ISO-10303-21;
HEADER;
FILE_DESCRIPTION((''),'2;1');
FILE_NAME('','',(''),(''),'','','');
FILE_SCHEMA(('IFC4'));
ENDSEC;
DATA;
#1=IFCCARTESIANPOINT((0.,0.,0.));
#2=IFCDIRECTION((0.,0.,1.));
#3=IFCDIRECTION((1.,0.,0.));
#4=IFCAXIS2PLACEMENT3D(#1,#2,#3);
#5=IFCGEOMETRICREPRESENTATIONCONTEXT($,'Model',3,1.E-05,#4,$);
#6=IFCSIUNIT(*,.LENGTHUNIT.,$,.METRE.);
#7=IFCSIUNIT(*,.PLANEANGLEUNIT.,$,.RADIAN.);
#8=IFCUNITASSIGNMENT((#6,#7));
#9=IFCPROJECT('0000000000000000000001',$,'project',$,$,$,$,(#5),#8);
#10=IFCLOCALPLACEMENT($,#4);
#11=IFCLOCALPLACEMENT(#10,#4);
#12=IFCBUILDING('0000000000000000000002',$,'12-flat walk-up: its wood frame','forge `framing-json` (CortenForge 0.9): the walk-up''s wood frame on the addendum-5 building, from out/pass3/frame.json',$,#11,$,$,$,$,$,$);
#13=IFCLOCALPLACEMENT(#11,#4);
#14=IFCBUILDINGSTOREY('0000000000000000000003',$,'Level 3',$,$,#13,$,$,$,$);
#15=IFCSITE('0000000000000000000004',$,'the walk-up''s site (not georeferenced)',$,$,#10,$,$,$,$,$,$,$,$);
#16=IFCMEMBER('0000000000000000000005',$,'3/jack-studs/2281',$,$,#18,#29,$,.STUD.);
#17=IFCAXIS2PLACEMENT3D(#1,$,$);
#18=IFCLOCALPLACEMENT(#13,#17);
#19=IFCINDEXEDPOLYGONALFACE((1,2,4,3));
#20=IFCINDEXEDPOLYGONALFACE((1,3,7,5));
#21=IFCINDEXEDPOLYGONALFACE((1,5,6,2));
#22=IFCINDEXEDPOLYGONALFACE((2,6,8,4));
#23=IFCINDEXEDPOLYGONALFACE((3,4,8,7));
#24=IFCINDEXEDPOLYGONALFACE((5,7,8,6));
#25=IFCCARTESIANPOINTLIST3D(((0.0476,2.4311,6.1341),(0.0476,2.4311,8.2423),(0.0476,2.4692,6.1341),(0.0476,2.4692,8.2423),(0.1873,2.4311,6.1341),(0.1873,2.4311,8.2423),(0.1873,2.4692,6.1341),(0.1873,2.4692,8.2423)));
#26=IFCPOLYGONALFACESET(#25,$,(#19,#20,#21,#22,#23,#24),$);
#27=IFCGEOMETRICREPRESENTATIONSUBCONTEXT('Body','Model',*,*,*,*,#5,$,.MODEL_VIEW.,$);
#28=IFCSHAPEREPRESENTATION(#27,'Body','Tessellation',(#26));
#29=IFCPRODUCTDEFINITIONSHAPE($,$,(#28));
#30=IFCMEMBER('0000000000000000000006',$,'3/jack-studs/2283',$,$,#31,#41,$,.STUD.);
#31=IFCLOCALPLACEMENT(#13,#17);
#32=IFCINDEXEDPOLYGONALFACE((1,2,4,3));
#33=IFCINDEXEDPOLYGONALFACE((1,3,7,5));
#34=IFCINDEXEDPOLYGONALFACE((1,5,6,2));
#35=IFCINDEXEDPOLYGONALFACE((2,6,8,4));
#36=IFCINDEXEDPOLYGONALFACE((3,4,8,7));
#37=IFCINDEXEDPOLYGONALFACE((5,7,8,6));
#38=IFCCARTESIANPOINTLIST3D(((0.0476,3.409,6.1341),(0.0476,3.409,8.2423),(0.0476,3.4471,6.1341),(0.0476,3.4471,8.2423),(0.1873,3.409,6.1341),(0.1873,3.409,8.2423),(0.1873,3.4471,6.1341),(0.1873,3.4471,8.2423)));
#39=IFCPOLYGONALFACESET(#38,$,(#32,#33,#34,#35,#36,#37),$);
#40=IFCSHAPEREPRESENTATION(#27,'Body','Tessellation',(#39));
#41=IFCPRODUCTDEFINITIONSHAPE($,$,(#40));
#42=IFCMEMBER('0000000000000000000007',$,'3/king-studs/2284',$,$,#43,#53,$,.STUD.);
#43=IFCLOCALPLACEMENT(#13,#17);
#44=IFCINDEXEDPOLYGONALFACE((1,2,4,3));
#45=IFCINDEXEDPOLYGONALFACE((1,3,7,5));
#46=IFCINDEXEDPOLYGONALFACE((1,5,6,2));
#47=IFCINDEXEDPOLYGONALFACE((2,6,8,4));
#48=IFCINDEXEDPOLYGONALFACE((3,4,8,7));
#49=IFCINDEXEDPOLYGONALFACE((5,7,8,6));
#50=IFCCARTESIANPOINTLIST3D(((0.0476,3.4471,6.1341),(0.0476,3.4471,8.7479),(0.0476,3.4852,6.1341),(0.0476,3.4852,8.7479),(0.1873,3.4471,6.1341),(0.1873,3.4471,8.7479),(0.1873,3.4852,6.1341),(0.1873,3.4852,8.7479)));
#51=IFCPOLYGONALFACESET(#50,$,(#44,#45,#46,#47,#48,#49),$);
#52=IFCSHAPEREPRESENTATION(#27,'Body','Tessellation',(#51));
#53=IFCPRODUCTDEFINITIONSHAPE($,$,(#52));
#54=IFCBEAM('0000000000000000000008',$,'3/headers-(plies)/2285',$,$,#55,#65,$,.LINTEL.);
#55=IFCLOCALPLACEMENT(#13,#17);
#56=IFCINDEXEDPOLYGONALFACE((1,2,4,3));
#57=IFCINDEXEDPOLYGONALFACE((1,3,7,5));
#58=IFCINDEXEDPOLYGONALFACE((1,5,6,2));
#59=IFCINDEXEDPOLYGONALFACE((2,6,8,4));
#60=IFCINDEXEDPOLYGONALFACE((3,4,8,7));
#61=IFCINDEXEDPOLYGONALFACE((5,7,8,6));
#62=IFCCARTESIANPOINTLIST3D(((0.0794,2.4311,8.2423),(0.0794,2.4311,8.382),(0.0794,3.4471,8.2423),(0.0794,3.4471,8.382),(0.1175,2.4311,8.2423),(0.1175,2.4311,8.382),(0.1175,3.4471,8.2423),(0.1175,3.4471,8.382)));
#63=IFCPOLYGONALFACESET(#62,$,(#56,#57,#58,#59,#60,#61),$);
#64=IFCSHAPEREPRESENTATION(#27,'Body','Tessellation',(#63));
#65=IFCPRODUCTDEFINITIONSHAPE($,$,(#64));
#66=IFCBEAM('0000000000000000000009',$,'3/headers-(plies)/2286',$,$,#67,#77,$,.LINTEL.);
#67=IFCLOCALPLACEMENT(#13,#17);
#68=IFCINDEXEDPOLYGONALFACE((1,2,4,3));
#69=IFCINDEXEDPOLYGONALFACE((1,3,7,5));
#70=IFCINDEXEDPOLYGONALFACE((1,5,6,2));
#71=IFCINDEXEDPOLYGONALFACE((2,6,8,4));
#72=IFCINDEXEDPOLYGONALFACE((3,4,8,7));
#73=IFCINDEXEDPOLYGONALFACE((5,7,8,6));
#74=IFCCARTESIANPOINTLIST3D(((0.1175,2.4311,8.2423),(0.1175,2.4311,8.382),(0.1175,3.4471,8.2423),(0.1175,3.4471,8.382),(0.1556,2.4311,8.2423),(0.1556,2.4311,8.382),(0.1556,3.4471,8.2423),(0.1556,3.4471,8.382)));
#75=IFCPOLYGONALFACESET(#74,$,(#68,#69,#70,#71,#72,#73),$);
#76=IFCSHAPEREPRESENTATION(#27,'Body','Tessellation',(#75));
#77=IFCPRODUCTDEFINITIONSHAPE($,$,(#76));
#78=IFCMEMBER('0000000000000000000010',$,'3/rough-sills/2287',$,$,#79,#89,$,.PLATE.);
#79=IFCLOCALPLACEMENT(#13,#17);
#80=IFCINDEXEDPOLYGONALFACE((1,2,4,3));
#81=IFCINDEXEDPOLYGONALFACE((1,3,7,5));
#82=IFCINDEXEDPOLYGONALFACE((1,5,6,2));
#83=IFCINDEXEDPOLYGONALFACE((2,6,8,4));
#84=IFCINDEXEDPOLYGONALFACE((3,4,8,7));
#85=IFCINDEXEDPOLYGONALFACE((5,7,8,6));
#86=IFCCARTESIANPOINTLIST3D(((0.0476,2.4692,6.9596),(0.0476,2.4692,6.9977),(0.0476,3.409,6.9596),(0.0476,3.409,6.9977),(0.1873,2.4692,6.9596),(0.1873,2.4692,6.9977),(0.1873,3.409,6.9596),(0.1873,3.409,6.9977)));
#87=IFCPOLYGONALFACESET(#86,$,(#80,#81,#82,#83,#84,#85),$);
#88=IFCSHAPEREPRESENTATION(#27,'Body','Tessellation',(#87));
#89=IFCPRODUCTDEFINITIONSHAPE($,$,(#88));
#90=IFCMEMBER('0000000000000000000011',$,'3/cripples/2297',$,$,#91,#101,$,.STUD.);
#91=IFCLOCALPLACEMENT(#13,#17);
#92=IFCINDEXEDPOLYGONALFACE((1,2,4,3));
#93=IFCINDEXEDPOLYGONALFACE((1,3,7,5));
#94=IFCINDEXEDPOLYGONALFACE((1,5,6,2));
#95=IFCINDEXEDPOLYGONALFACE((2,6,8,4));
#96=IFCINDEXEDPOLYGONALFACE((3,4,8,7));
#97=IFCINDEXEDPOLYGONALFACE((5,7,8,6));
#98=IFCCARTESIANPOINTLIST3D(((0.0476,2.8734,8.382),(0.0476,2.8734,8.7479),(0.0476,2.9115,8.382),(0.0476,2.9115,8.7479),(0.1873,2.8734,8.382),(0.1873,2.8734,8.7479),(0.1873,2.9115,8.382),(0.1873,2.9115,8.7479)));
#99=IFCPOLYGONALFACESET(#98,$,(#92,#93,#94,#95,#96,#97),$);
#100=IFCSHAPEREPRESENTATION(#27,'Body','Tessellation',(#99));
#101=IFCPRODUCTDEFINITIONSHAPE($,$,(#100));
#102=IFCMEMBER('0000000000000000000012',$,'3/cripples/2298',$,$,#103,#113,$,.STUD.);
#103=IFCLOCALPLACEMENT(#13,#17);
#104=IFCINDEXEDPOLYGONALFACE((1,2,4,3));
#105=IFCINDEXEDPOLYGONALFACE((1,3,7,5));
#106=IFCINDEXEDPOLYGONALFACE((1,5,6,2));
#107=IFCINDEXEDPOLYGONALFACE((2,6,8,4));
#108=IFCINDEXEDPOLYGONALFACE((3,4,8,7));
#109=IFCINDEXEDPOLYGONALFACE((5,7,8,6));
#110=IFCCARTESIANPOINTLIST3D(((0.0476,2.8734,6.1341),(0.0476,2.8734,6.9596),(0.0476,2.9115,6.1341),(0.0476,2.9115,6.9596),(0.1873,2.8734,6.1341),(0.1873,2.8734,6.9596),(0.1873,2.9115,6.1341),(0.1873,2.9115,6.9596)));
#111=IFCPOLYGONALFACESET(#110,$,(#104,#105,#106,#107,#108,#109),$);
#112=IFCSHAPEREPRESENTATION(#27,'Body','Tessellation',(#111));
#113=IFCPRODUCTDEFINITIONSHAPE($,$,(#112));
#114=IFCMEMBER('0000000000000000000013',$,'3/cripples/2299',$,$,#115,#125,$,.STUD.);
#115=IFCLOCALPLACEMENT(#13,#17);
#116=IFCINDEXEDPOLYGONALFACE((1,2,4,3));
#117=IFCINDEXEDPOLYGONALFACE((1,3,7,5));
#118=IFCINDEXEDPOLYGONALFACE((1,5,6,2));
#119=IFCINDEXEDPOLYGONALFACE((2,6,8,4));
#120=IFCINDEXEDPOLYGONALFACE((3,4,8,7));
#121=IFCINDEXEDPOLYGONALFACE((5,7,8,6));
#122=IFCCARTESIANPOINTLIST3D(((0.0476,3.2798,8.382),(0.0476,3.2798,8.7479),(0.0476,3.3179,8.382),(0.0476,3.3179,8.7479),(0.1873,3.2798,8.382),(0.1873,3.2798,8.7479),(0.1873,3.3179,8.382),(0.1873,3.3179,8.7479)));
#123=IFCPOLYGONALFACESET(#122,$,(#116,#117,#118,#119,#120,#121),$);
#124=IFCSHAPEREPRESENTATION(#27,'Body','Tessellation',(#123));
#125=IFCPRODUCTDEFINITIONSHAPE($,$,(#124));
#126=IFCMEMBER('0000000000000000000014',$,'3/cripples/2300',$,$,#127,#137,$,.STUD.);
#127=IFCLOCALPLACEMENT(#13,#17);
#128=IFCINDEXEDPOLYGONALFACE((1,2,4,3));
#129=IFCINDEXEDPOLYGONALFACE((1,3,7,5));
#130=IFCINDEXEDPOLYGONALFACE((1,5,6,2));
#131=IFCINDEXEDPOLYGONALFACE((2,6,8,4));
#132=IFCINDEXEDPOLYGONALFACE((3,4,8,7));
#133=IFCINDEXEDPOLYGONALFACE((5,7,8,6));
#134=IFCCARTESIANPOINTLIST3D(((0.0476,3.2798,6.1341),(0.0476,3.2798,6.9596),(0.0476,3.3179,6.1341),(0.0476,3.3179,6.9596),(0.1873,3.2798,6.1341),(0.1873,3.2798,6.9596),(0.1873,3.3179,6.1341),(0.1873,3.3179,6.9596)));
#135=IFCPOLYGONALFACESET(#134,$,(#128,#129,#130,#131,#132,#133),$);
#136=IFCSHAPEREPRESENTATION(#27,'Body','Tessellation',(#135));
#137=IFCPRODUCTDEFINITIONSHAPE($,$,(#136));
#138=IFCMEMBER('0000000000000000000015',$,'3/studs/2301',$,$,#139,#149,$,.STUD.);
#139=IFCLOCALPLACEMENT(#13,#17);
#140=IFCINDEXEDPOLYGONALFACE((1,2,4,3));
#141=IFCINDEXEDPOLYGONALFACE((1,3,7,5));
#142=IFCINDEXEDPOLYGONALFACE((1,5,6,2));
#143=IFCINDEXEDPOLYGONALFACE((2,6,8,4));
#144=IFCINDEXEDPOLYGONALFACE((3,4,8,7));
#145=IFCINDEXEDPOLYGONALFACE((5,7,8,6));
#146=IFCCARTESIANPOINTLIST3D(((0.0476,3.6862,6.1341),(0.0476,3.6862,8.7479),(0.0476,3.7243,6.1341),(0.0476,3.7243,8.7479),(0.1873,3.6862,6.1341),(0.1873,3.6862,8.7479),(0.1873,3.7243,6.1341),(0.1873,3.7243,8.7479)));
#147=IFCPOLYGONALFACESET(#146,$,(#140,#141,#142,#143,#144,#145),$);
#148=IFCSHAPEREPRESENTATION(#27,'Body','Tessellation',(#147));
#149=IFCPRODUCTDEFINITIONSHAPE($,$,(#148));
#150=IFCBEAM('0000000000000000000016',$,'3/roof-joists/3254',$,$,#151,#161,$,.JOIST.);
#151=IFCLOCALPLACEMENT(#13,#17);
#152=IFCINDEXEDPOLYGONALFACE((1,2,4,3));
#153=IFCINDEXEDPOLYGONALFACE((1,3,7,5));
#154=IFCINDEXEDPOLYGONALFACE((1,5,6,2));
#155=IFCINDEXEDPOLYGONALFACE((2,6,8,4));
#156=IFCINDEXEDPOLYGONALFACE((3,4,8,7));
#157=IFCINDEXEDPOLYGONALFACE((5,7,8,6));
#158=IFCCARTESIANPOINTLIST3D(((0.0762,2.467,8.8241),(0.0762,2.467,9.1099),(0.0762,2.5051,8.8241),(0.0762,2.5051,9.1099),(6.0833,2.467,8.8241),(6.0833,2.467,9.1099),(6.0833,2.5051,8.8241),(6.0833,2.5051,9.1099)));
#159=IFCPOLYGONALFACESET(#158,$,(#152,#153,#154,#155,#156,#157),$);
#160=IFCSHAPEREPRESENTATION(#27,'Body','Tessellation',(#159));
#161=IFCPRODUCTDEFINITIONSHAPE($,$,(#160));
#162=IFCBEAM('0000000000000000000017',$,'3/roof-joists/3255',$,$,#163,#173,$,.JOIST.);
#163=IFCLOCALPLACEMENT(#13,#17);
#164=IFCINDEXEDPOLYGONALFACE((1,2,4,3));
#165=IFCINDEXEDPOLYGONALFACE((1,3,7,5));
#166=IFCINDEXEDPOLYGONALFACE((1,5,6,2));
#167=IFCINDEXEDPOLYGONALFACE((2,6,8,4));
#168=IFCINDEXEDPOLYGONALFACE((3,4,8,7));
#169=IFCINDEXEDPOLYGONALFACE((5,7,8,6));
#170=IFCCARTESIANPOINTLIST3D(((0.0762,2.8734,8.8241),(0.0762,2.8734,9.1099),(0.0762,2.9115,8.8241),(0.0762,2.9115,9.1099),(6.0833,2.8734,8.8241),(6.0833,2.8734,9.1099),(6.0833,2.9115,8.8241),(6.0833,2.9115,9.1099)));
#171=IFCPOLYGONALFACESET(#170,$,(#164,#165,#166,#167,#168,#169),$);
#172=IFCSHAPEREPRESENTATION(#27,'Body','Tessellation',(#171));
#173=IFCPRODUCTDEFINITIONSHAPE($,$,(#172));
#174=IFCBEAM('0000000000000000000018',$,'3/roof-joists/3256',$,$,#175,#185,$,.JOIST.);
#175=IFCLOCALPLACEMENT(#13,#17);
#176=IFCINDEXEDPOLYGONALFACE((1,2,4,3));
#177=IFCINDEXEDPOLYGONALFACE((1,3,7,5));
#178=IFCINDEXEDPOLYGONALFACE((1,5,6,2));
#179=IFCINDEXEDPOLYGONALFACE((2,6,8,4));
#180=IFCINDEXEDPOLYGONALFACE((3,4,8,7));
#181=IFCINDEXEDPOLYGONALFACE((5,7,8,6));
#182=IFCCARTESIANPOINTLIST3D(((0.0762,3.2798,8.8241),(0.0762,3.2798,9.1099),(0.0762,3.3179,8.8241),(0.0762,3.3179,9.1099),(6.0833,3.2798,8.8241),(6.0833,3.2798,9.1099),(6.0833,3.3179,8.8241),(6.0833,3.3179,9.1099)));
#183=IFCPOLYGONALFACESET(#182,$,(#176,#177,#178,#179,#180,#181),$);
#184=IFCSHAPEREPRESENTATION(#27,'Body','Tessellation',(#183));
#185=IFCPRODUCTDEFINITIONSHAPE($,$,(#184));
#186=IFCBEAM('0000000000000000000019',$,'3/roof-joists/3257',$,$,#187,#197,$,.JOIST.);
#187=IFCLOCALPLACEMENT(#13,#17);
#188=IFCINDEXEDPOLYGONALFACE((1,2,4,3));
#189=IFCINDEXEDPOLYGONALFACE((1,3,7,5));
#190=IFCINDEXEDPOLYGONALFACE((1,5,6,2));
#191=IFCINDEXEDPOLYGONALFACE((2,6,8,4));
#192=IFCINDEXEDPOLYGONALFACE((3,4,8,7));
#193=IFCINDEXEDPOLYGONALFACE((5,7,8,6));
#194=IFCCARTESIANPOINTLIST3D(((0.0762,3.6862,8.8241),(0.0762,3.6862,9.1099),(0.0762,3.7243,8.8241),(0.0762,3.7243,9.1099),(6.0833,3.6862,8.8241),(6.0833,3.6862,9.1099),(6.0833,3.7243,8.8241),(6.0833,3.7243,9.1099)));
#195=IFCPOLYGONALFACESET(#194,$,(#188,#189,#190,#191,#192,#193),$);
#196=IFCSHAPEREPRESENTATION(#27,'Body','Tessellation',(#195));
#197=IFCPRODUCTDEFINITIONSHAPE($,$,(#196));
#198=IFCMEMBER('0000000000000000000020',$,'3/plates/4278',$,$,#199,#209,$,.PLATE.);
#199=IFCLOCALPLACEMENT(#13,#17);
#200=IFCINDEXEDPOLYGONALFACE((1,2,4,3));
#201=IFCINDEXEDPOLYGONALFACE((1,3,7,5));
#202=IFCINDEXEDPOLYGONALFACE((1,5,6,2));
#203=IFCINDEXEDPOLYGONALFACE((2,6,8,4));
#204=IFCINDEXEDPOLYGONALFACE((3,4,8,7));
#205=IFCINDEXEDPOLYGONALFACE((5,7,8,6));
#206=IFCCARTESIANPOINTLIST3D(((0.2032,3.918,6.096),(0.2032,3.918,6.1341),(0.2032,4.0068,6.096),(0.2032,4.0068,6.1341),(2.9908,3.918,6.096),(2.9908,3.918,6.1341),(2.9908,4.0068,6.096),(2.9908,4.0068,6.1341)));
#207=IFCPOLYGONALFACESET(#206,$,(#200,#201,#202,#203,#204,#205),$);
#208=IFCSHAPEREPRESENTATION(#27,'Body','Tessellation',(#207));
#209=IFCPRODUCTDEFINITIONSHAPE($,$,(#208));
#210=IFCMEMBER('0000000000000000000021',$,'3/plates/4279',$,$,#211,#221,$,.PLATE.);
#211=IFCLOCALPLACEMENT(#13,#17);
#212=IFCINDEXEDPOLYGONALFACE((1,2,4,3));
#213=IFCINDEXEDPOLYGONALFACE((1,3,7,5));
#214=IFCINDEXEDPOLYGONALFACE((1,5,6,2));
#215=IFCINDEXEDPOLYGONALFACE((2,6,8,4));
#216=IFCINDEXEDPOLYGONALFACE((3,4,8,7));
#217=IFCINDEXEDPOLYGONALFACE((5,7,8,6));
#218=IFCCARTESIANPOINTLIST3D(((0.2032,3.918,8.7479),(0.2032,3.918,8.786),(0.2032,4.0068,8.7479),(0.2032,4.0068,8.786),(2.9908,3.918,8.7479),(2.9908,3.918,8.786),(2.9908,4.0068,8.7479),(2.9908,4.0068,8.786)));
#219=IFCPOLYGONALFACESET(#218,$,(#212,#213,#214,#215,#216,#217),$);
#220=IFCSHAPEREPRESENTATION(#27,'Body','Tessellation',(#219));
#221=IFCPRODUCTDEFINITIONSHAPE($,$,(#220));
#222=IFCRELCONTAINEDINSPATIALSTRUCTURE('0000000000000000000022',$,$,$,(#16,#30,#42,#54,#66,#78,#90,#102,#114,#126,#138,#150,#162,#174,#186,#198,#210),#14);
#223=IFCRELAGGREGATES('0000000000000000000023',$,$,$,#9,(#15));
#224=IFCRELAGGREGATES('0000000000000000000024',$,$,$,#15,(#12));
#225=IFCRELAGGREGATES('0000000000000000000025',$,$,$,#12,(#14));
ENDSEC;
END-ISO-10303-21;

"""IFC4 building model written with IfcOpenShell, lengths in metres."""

from ifc_helpers import new_model, si_unit, frame, frame_2d, origin, origin_with_axes, place, context, subcontext, project, spatial, rectangle, extrude, element, save


model = new_model("IFC4")

# Units and contexts
model_context = context("Model", 3, precision=1e-05, world=origin_with_axes())
body_context = subcontext(model_context, "Body", "Model", "MODEL_VIEW")
ifc_project = project(units=[si_unit("LENGTHUNIT", "METRE"), si_unit("PLANEANGLEUNIT", "RADIAN")], contexts=[model_context])

# Site, building, storey
site_placement = place(None, origin_with_axes())
site = spatial("IfcSite", under=ifc_project, at=site_placement, Name="the walk-up's site (not georeferenced)")
building_placement = place(site_placement, origin_with_axes())
building = spatial("IfcBuilding", under=site, at=building_placement, Name="12-flat walk-up: its wood frame", Description="forge `framing-json` (CortenForge 0.9): the walk-up's wood frame on the addendum-5 building, from out/pass3/frame.json")
storey_placement = place(building_placement, origin_with_axes())
storey = spatial("IfcBuildingStorey", under=building, at=storey_placement, Name="Level 3")

# Members
for number, where, z_axis, x_axis, name in (
    (1, (0.0476, 2.4311, 6.1341), (0.0, 0.0, 1.0), (1.0, 0.0, 0.0), "3/jack-studs/2281"),
    (2, (0.0476, 3.409, 6.1341), (0.0, 0.0, 1.0), (1.0, 0.0, 0.0), "3/jack-studs/2283"),
):
    element("IfcMember", number, at=place(storey_placement, frame(where, z_axis=z_axis, x_axis=x_axis)), inside=storey, Name=name, PredefinedType="STUD", context=body_context, shape_type="SweptSolid", body=[
        extrude(rectangle(XDim=0.1397, YDim=0.0381, at=frame_2d((0.0698, 0.0191))), origin(), (0.0, 0.0, 1.0), 2.1082),
    ])
member_1_placement = place(storey_placement, frame((0.0476, 3.4471, 6.1341), z_axis=(0.0, 0.0, 1.0), x_axis=(1.0, 0.0, 0.0)))
element("IfcMember", 3, at=member_1_placement, inside=storey, Name="3/king-studs/2284", PredefinedType="STUD", context=body_context, shape_type="SweptSolid", body=[
    extrude(rectangle(XDim=0.1397, YDim=0.0381, at=frame_2d((0.0698, 0.0191))), origin(), (0.0, 0.0, 1.0), 2.6138),
])

# Beams
for number, where, z_axis, x_axis, name in (
    (4, (0.0794, 2.4311, 8.2423), (0.0, 0.0, 1.0), (1.0, 0.0, 0.0), "3/headers-(plies)/2285"),
    (5, (0.1175, 2.4311, 8.2423), (0.0, 0.0, 1.0), (1.0, 0.0, 0.0), "3/headers-(plies)/2286"),
):
    element("IfcBeam", number, at=place(storey_placement, frame(where, z_axis=z_axis, x_axis=x_axis)), inside=storey, Name=name, PredefinedType="LINTEL", context=body_context, shape_type="SweptSolid", body=[
        extrude(rectangle(XDim=0.0381, YDim=1.016, at=frame_2d((0.019, 0.508))), origin(), (0.0, 0.0, 1.0), 0.1397),
    ])

# Members
member_2_placement = place(storey_placement, frame((0.0476, 2.4692, 6.9596), z_axis=(0.0, 0.0, 1.0), x_axis=(1.0, 0.0, 0.0)))
element("IfcMember", 6, at=member_2_placement, inside=storey, Name="3/rough-sills/2287", PredefinedType="PLATE", context=body_context, shape_type="SweptSolid", body=[
    extrude(rectangle(XDim=0.1397, YDim=0.9398, at=frame_2d((0.0698, 0.4699))), origin(), (0.0, 0.0, 1.0), 0.0381),
])
member_3_placement = place(storey_placement, frame((0.0476, 2.8734, 8.382), z_axis=(0.0, 0.0, 1.0), x_axis=(1.0, 0.0, 0.0)))
element("IfcMember", 7, at=member_3_placement, inside=storey, Name="3/cripples/2297", PredefinedType="STUD", context=body_context, shape_type="SweptSolid", body=[
    extrude(rectangle(XDim=0.1397, YDim=0.0381, at=frame_2d((0.0698, 0.0191))), origin(), (0.0, 0.0, 1.0), 0.3659),
])
member_4_placement = place(storey_placement, frame((0.0476, 2.8734, 6.1341), z_axis=(0.0, 0.0, 1.0), x_axis=(1.0, 0.0, 0.0)))
element("IfcMember", 8, at=member_4_placement, inside=storey, Name="3/cripples/2298", PredefinedType="STUD", context=body_context, shape_type="SweptSolid", body=[
    extrude(rectangle(XDim=0.1397, YDim=0.0381, at=frame_2d((0.0698, 0.0191))), origin(), (0.0, 0.0, 1.0), 0.8255),
])
member_5_placement = place(storey_placement, frame((0.0476, 3.2798, 8.382), z_axis=(0.0, 0.0, 1.0), x_axis=(1.0, 0.0, 0.0)))
element("IfcMember", 9, at=member_5_placement, inside=storey, Name="3/cripples/2299", PredefinedType="STUD", context=body_context, shape_type="SweptSolid", body=[
    extrude(rectangle(XDim=0.1397, YDim=0.0381, at=frame_2d((0.0698, 0.0191))), origin(), (0.0, 0.0, 1.0), 0.3659),
])
member_6_placement = place(storey_placement, frame((0.0476, 3.2798, 6.1341), z_axis=(0.0, 0.0, 1.0), x_axis=(1.0, 0.0, 0.0)))
element("IfcMember", 10, at=member_6_placement, inside=storey, Name="3/cripples/2300", PredefinedType="STUD", context=body_context, shape_type="SweptSolid", body=[
    extrude(rectangle(XDim=0.1397, YDim=0.0381, at=frame_2d((0.0698, 0.0191))), origin(), (0.0, 0.0, 1.0), 0.8255),
])
member_7_placement = place(storey_placement, frame((0.0476, 3.6862, 6.1341), z_axis=(0.0, 0.0, 1.0), x_axis=(1.0, 0.0, 0.0)))
element("IfcMember", 11, at=member_7_placement, inside=storey, Name="3/studs/2301", PredefinedType="STUD", context=body_context, shape_type="SweptSolid", body=[
    extrude(rectangle(XDim=0.1397, YDim=0.0381, at=frame_2d((0.0698, 0.0191))), origin(), (0.0, 0.0, 1.0), 2.6138),
])

# Beams
for number, where, z_axis, x_axis, name in (
    (12, (0.0762, 2.467, 8.8241), (0.0, 0.0, 1.0), (1.0, 0.0, 0.0), "3/roof-joists/3254"),
    (13, (0.0762, 2.8734, 8.8241), (0.0, 0.0, 1.0), (1.0, 0.0, 0.0), "3/roof-joists/3255"),
    (14, (0.0762, 3.2798, 8.8241), (0.0, 0.0, 1.0), (1.0, 0.0, 0.0), "3/roof-joists/3256"),
    (15, (0.0762, 3.6862, 8.8241), (0.0, 0.0, 1.0), (1.0, 0.0, 0.0), "3/roof-joists/3257"),
):
    element("IfcBeam", number, at=place(storey_placement, frame(where, z_axis=z_axis, x_axis=x_axis)), inside=storey, Name=name, PredefinedType="JOIST", context=body_context, shape_type="SweptSolid", body=[
        extrude(rectangle(XDim=6.0071, YDim=0.0381, at=frame_2d((3.0036, 0.0191))), origin(), (0.0, 0.0, 1.0), 0.2858),
    ])

# Members
for number, where, z_axis, x_axis, name in (
    (16, (0.2032, 3.9179, 6.096), (0.0, 0.0, 1.0), (1.0, 0.0, 0.0), "3/plates/4278"),
    (17, (0.2032, 3.9179, 8.7479), (0.0, 0.0, 1.0), (1.0, 0.0, 0.0), "3/plates/4279"),
):
    element("IfcMember", number, at=place(storey_placement, frame(where, z_axis=z_axis, x_axis=x_axis)), inside=storey, Name=name, PredefinedType="PLATE", context=body_context, shape_type="SweptSolid", body=[
        extrude(rectangle(XDim=2.7877, YDim=0.0889, at=frame_2d((1.3938, 0.0445))), origin(), (0.0, 0.0, 1.0), 0.0381),
    ])

save(model, "model.ifc")
